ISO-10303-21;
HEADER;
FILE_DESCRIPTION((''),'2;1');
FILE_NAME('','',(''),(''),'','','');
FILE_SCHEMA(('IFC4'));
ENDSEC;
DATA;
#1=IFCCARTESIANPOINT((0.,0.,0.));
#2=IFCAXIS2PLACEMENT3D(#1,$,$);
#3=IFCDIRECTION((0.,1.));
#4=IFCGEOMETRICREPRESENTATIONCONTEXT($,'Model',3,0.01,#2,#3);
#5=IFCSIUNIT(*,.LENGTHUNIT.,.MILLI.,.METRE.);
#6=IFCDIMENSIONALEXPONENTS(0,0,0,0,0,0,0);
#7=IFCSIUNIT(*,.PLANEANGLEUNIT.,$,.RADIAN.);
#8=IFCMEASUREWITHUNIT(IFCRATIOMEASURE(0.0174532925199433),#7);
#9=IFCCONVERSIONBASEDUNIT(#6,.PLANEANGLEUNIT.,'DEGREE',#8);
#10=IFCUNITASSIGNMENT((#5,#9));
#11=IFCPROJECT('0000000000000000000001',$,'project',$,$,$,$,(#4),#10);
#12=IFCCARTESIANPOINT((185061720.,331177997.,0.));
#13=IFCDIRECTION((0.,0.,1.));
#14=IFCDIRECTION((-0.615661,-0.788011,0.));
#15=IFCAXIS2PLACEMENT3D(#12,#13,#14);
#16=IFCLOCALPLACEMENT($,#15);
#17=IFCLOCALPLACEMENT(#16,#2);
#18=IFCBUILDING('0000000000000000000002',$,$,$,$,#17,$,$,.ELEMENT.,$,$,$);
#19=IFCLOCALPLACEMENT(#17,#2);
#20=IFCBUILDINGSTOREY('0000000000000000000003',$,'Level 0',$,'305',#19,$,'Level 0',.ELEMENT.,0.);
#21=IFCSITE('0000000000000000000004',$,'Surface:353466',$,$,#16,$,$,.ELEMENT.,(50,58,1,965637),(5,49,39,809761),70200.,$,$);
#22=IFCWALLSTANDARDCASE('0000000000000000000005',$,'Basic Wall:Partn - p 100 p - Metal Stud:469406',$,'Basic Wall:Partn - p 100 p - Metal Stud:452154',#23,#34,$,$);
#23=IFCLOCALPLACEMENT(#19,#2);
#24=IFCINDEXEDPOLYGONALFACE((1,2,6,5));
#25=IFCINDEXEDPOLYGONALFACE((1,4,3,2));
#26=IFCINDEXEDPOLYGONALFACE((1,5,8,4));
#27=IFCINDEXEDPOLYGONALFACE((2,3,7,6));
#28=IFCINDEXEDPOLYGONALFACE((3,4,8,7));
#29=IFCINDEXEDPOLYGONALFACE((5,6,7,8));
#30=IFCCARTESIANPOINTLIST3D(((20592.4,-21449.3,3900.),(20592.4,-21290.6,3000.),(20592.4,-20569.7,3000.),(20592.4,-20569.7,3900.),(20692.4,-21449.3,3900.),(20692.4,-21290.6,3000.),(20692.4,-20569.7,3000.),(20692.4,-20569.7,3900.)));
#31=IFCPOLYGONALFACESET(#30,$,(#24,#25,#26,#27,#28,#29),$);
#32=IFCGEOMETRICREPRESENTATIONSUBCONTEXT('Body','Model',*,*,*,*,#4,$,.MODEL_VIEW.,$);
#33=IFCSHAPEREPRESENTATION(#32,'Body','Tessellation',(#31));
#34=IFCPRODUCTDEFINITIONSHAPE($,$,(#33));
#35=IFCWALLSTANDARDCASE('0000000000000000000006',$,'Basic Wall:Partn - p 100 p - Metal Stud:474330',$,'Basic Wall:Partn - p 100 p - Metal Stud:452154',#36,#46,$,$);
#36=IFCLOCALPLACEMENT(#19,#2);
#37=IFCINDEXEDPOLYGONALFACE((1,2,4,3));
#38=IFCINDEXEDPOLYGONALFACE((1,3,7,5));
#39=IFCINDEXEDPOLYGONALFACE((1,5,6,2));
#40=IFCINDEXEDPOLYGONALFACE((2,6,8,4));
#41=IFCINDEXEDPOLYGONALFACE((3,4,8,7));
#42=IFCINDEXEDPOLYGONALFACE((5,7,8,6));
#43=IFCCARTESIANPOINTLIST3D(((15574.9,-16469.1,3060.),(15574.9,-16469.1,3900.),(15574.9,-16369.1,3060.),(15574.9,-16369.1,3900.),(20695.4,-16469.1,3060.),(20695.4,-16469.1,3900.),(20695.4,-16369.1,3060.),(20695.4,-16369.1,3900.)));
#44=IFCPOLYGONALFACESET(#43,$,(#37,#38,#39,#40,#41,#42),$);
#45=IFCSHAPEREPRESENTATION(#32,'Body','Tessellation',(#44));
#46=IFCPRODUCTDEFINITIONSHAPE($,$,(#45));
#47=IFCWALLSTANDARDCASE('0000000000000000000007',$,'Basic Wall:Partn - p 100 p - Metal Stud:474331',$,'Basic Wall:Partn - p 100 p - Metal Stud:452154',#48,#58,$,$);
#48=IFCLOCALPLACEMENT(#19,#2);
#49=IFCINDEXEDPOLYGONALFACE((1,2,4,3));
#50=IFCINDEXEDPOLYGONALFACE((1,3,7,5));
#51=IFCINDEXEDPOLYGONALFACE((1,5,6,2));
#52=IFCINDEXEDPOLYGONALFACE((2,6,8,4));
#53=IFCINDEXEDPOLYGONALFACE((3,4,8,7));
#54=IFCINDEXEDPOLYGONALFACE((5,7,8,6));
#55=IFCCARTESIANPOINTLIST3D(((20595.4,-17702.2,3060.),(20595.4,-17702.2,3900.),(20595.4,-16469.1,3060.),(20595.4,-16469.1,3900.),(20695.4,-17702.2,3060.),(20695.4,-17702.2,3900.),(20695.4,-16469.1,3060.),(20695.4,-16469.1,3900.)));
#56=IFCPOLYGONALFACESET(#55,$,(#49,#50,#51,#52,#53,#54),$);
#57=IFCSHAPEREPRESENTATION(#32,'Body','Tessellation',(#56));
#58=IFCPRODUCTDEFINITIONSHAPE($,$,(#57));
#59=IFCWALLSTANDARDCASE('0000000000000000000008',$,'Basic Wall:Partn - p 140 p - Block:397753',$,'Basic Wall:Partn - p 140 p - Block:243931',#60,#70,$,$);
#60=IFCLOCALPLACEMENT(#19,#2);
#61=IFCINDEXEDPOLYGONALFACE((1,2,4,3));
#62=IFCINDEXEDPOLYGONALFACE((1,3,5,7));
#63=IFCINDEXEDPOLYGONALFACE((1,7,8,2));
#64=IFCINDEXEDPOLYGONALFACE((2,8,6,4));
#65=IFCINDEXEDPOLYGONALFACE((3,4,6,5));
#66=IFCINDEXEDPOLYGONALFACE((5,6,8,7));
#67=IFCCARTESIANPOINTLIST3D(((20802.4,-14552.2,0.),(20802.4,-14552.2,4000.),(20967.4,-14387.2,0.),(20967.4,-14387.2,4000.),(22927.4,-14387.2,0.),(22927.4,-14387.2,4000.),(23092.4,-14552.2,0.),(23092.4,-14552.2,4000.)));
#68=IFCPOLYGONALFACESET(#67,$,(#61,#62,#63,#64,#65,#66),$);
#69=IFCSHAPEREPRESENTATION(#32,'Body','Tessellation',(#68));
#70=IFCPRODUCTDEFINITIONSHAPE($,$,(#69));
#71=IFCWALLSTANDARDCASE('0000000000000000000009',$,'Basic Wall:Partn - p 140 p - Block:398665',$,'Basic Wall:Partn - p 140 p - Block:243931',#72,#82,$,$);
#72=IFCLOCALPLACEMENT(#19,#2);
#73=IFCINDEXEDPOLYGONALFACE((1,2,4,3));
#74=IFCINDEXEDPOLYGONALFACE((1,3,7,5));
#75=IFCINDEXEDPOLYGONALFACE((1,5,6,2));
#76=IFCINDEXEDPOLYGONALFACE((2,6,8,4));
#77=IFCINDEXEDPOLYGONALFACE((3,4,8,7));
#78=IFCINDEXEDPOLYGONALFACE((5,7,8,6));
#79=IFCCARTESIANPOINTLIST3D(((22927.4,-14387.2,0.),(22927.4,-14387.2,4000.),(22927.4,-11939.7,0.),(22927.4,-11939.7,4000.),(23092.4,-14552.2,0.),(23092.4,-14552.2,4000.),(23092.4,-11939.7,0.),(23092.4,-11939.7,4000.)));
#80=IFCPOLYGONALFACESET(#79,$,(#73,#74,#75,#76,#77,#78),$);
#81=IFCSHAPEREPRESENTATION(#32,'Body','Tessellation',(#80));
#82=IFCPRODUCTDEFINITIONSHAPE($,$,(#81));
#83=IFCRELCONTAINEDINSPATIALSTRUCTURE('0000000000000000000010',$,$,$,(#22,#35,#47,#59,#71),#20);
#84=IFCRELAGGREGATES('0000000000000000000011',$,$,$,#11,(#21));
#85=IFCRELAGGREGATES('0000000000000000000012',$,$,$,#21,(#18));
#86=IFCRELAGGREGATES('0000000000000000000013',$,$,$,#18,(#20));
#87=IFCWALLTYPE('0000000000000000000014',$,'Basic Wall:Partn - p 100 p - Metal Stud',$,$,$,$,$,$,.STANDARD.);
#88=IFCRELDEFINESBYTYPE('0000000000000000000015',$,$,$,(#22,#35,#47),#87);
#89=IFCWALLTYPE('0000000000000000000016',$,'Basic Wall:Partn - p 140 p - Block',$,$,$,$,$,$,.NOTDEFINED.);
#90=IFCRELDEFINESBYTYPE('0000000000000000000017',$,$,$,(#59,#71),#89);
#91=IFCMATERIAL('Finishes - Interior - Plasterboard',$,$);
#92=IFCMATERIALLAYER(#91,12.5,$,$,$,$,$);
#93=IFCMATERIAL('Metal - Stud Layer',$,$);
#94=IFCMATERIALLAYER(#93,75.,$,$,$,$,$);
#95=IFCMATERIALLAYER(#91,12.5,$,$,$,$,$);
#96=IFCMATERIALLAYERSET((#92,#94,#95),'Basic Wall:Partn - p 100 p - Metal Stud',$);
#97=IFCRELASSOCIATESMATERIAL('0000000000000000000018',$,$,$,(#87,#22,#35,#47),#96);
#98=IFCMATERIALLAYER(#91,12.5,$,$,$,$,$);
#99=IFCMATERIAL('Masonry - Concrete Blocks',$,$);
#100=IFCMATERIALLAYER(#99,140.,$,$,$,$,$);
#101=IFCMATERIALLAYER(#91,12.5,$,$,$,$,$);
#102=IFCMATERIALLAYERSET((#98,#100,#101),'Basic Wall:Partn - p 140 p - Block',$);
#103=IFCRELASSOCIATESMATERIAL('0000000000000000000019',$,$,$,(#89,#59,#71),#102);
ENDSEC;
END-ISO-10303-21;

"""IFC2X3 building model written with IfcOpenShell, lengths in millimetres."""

from ifc_helpers import new_model, entity, si_unit, converted_unit, direction, frame, frame_2d, origin, place, context, subcontext, project, spatial, polyline, rectangle, outline, extrude, clip, halfspace, material, layer, layer_set, layer_usage, type_object, element, save


model = new_model("IFC2X3")

# Units and contexts
model_context = context("Model", 3, precision=0.01, world=origin(), true_north=direction((0.0, 1.0)))
body_context = subcontext(model_context, "Body", "Model", "MODEL_VIEW")
ifc_project = project(units=[si_unit("LENGTHUNIT", "METRE", prefix="MILLI"), converted_unit("PLANEANGLEUNIT", "DEGREE", entity("IfcRatioMeasure", 0.0174532925199433), si_unit("PLANEANGLEUNIT", "RADIAN"), dimensions=[0, 0, 0, 0, 0, 0, 0])], contexts=[model_context])

# Site, building, storey
site_placement = place(None, frame((185061720.0, 331177997.0, 0.0), z_axis=(0.0, 0.0, 1.0), x_axis=(-0.615661, -0.788011, 0.0)))
site = spatial("IfcSite", under=ifc_project, at=site_placement, Name="Surface:353466", CompositionType="ELEMENT", RefLatitude=(50, 58, 1, 965637), RefLongitude=(5, 49, 39, 809761), RefElevation=70200.0)
building_placement = place(site_placement, origin())
building = spatial("IfcBuilding", under=site, at=building_placement, CompositionType="ELEMENT")
storey_placement = place(building_placement, origin())
storey = spatial("IfcBuildingStorey", under=building, at=storey_placement, Name="Level 0", ObjectType="305", LongName="Level 0", CompositionType="ELEMENT", Elevation=0.0)

# Shared definitions
ifc_material_1 = material(Name="Masonry - Concrete Blocks")
ifc_material_2 = material(Name="Finishes - Interior - Plasterboard")

# Walls
ifc_layer_1 = layer(ifc_material_2, 12.5)
ifc_material_3 = material(Name="Metal - Stud Layer")
ifc_layer_2 = layer(ifc_material_3, 75.0)
ifc_layer_3 = layer(ifc_material_2, 12.5)
ifc_layer_set_1 = layer_set([ifc_layer_1, ifc_layer_2, ifc_layer_3], Name="Basic Wall:Partn - p 100 p - Metal Stud")
wall_type_1 = type_object("IfcWallType", Name="Basic Wall:Partn - p 100 p - Metal Stud", PredefinedType="STANDARD", material=ifc_layer_set_1)
ifc_layer_usage_1 = layer_usage(ifc_layer_set_1, "AXIS2", "POSITIVE", -50.0)
wall_1_placement = place(storey_placement, frame((20642.4, -20569.7, 3000.0), z_axis=(0.0, 0.0, 1.0), x_axis=(0.0, -1.0, 0.0)))
element("IfcWallStandardCase", 1, at=wall_1_placement, inside=storey, type_object=wall_type_1, material=ifc_layer_usage_1, Name="Basic Wall:Partn - p 100 p - Metal Stud:469406", ObjectType="Basic Wall:Partn - p 100 p - Metal Stud:452154", context=body_context, shape_type="Clipping", body=[
    clip(extrude(rectangle(XDim=879.6, YDim=100.0, at=frame_2d((439.8, 0.0), x_axis=(-1.0, 0.0))), origin(), (0.0, 0.0, 1.0), 900.0), halfspace(frame((879.6, -50.0, 900.0), z_axis=(0.984808, 0.0, -0.173648), x_axis=(0.0, 1.0, 0.0)), False)),
])
ifc_layer_usage_2 = layer_usage(ifc_layer_set_1, "AXIS2", "POSITIVE", -50.0)
wall_2_placement = place(storey_placement, frame((20695.4, -16419.1, 3060.0), z_axis=(0.0, 0.0, 1.0), x_axis=(-1.0, 0.0, 0.0)))
element("IfcWallStandardCase", 2, at=wall_2_placement, inside=storey, type_object=wall_type_1, material=ifc_layer_usage_2, Name="Basic Wall:Partn - p 100 p - Metal Stud:474330", ObjectType="Basic Wall:Partn - p 100 p - Metal Stud:452154", context=body_context, shape_type="SweptSolid", body=[
    extrude(rectangle(XDim=5120.5, YDim=100.0, at=frame_2d((2560.3, 0.0), x_axis=(-1.0, 0.0))), origin(), (0.0, 0.0, 1.0), 840.0),
])
ifc_layer_usage_3 = layer_usage(ifc_layer_set_1, "AXIS2", "POSITIVE", -50.0)
wall_3_placement = place(storey_placement, frame((20645.4, -17702.2, 3060.0), z_axis=(0.0, 0.0, 1.0), x_axis=(0.0, 1.0, 0.0)))
element("IfcWallStandardCase", 3, at=wall_3_placement, inside=storey, type_object=wall_type_1, material=ifc_layer_usage_3, Name="Basic Wall:Partn - p 100 p - Metal Stud:474331", ObjectType="Basic Wall:Partn - p 100 p - Metal Stud:452154", context=body_context, shape_type="SweptSolid", body=[
    extrude(rectangle(XDim=1233.1, YDim=100.0, at=frame_2d((616.6, 0.0), x_axis=(-1.0, 0.0))), origin(), (0.0, 0.0, 1.0), 840.0),
])

# Walls
ifc_layer_4 = layer(ifc_material_2, 12.5)
ifc_layer_5 = layer(ifc_material_1, 140.0)
ifc_layer_6 = layer(ifc_material_2, 12.5)
ifc_layer_set_2 = layer_set([ifc_layer_4, ifc_layer_5, ifc_layer_6], Name="Basic Wall:Partn - p 140 p - Block")
ifc_layer_usage_4 = layer_usage(ifc_layer_set_2, "AXIS2", "NEGATIVE", 82.5)
wall_type_2 = type_object("IfcWallType", Name="Basic Wall:Partn - p 140 p - Block", PredefinedType="NOTDEFINED", material=ifc_layer_set_2)
wall_4_placement = place(storey_placement, frame((23092.4, -14469.7, 0.0), z_axis=(0.0, 0.0, 1.0), x_axis=(-1.0, 0.0, 0.0)))
element("IfcWallStandardCase", 4, at=wall_4_placement, inside=storey, type_object=wall_type_2, material=ifc_layer_usage_4, Name="Basic Wall:Partn - p 140 p - Block:397753", ObjectType="Basic Wall:Partn - p 140 p - Block:243931", context=body_context, shape_type="Clipping", body=[
    clip(extrude(outline(polyline([(2125.0, -82.5), (2290.0, 82.5), (0.0, 82.5), (165.0, -82.5), (2125.0, -82.5)])), origin(), (0.0, 0.0, 1.0), 4000.0), halfspace(origin(), True)),
])
ifc_layer_usage_5 = layer_usage(ifc_layer_set_2, "AXIS2", "NEGATIVE", 82.5)
wall_5_placement = place(storey_placement, frame((23009.9, -14552.2, 0.0), z_axis=(0.0, 0.0, 1.0), x_axis=(0.0, 1.0, 0.0)))
element("IfcWallStandardCase", 5, at=wall_5_placement, inside=storey, type_object=wall_type_2, material=ifc_layer_usage_5, Name="Basic Wall:Partn - p 140 p - Block:398665", ObjectType="Basic Wall:Partn - p 140 p - Block:243931", context=body_context, shape_type="Clipping", body=[
    clip(extrude(outline(polyline([(2612.5, -82.5), (2612.5, 82.5), (165.0, 82.5), (0.0, -82.5), (2612.5, -82.5)])), origin(), (0.0, 0.0, 1.0), 4000.0), halfspace(origin(), True)),
])

save(model, "model.ifc")
